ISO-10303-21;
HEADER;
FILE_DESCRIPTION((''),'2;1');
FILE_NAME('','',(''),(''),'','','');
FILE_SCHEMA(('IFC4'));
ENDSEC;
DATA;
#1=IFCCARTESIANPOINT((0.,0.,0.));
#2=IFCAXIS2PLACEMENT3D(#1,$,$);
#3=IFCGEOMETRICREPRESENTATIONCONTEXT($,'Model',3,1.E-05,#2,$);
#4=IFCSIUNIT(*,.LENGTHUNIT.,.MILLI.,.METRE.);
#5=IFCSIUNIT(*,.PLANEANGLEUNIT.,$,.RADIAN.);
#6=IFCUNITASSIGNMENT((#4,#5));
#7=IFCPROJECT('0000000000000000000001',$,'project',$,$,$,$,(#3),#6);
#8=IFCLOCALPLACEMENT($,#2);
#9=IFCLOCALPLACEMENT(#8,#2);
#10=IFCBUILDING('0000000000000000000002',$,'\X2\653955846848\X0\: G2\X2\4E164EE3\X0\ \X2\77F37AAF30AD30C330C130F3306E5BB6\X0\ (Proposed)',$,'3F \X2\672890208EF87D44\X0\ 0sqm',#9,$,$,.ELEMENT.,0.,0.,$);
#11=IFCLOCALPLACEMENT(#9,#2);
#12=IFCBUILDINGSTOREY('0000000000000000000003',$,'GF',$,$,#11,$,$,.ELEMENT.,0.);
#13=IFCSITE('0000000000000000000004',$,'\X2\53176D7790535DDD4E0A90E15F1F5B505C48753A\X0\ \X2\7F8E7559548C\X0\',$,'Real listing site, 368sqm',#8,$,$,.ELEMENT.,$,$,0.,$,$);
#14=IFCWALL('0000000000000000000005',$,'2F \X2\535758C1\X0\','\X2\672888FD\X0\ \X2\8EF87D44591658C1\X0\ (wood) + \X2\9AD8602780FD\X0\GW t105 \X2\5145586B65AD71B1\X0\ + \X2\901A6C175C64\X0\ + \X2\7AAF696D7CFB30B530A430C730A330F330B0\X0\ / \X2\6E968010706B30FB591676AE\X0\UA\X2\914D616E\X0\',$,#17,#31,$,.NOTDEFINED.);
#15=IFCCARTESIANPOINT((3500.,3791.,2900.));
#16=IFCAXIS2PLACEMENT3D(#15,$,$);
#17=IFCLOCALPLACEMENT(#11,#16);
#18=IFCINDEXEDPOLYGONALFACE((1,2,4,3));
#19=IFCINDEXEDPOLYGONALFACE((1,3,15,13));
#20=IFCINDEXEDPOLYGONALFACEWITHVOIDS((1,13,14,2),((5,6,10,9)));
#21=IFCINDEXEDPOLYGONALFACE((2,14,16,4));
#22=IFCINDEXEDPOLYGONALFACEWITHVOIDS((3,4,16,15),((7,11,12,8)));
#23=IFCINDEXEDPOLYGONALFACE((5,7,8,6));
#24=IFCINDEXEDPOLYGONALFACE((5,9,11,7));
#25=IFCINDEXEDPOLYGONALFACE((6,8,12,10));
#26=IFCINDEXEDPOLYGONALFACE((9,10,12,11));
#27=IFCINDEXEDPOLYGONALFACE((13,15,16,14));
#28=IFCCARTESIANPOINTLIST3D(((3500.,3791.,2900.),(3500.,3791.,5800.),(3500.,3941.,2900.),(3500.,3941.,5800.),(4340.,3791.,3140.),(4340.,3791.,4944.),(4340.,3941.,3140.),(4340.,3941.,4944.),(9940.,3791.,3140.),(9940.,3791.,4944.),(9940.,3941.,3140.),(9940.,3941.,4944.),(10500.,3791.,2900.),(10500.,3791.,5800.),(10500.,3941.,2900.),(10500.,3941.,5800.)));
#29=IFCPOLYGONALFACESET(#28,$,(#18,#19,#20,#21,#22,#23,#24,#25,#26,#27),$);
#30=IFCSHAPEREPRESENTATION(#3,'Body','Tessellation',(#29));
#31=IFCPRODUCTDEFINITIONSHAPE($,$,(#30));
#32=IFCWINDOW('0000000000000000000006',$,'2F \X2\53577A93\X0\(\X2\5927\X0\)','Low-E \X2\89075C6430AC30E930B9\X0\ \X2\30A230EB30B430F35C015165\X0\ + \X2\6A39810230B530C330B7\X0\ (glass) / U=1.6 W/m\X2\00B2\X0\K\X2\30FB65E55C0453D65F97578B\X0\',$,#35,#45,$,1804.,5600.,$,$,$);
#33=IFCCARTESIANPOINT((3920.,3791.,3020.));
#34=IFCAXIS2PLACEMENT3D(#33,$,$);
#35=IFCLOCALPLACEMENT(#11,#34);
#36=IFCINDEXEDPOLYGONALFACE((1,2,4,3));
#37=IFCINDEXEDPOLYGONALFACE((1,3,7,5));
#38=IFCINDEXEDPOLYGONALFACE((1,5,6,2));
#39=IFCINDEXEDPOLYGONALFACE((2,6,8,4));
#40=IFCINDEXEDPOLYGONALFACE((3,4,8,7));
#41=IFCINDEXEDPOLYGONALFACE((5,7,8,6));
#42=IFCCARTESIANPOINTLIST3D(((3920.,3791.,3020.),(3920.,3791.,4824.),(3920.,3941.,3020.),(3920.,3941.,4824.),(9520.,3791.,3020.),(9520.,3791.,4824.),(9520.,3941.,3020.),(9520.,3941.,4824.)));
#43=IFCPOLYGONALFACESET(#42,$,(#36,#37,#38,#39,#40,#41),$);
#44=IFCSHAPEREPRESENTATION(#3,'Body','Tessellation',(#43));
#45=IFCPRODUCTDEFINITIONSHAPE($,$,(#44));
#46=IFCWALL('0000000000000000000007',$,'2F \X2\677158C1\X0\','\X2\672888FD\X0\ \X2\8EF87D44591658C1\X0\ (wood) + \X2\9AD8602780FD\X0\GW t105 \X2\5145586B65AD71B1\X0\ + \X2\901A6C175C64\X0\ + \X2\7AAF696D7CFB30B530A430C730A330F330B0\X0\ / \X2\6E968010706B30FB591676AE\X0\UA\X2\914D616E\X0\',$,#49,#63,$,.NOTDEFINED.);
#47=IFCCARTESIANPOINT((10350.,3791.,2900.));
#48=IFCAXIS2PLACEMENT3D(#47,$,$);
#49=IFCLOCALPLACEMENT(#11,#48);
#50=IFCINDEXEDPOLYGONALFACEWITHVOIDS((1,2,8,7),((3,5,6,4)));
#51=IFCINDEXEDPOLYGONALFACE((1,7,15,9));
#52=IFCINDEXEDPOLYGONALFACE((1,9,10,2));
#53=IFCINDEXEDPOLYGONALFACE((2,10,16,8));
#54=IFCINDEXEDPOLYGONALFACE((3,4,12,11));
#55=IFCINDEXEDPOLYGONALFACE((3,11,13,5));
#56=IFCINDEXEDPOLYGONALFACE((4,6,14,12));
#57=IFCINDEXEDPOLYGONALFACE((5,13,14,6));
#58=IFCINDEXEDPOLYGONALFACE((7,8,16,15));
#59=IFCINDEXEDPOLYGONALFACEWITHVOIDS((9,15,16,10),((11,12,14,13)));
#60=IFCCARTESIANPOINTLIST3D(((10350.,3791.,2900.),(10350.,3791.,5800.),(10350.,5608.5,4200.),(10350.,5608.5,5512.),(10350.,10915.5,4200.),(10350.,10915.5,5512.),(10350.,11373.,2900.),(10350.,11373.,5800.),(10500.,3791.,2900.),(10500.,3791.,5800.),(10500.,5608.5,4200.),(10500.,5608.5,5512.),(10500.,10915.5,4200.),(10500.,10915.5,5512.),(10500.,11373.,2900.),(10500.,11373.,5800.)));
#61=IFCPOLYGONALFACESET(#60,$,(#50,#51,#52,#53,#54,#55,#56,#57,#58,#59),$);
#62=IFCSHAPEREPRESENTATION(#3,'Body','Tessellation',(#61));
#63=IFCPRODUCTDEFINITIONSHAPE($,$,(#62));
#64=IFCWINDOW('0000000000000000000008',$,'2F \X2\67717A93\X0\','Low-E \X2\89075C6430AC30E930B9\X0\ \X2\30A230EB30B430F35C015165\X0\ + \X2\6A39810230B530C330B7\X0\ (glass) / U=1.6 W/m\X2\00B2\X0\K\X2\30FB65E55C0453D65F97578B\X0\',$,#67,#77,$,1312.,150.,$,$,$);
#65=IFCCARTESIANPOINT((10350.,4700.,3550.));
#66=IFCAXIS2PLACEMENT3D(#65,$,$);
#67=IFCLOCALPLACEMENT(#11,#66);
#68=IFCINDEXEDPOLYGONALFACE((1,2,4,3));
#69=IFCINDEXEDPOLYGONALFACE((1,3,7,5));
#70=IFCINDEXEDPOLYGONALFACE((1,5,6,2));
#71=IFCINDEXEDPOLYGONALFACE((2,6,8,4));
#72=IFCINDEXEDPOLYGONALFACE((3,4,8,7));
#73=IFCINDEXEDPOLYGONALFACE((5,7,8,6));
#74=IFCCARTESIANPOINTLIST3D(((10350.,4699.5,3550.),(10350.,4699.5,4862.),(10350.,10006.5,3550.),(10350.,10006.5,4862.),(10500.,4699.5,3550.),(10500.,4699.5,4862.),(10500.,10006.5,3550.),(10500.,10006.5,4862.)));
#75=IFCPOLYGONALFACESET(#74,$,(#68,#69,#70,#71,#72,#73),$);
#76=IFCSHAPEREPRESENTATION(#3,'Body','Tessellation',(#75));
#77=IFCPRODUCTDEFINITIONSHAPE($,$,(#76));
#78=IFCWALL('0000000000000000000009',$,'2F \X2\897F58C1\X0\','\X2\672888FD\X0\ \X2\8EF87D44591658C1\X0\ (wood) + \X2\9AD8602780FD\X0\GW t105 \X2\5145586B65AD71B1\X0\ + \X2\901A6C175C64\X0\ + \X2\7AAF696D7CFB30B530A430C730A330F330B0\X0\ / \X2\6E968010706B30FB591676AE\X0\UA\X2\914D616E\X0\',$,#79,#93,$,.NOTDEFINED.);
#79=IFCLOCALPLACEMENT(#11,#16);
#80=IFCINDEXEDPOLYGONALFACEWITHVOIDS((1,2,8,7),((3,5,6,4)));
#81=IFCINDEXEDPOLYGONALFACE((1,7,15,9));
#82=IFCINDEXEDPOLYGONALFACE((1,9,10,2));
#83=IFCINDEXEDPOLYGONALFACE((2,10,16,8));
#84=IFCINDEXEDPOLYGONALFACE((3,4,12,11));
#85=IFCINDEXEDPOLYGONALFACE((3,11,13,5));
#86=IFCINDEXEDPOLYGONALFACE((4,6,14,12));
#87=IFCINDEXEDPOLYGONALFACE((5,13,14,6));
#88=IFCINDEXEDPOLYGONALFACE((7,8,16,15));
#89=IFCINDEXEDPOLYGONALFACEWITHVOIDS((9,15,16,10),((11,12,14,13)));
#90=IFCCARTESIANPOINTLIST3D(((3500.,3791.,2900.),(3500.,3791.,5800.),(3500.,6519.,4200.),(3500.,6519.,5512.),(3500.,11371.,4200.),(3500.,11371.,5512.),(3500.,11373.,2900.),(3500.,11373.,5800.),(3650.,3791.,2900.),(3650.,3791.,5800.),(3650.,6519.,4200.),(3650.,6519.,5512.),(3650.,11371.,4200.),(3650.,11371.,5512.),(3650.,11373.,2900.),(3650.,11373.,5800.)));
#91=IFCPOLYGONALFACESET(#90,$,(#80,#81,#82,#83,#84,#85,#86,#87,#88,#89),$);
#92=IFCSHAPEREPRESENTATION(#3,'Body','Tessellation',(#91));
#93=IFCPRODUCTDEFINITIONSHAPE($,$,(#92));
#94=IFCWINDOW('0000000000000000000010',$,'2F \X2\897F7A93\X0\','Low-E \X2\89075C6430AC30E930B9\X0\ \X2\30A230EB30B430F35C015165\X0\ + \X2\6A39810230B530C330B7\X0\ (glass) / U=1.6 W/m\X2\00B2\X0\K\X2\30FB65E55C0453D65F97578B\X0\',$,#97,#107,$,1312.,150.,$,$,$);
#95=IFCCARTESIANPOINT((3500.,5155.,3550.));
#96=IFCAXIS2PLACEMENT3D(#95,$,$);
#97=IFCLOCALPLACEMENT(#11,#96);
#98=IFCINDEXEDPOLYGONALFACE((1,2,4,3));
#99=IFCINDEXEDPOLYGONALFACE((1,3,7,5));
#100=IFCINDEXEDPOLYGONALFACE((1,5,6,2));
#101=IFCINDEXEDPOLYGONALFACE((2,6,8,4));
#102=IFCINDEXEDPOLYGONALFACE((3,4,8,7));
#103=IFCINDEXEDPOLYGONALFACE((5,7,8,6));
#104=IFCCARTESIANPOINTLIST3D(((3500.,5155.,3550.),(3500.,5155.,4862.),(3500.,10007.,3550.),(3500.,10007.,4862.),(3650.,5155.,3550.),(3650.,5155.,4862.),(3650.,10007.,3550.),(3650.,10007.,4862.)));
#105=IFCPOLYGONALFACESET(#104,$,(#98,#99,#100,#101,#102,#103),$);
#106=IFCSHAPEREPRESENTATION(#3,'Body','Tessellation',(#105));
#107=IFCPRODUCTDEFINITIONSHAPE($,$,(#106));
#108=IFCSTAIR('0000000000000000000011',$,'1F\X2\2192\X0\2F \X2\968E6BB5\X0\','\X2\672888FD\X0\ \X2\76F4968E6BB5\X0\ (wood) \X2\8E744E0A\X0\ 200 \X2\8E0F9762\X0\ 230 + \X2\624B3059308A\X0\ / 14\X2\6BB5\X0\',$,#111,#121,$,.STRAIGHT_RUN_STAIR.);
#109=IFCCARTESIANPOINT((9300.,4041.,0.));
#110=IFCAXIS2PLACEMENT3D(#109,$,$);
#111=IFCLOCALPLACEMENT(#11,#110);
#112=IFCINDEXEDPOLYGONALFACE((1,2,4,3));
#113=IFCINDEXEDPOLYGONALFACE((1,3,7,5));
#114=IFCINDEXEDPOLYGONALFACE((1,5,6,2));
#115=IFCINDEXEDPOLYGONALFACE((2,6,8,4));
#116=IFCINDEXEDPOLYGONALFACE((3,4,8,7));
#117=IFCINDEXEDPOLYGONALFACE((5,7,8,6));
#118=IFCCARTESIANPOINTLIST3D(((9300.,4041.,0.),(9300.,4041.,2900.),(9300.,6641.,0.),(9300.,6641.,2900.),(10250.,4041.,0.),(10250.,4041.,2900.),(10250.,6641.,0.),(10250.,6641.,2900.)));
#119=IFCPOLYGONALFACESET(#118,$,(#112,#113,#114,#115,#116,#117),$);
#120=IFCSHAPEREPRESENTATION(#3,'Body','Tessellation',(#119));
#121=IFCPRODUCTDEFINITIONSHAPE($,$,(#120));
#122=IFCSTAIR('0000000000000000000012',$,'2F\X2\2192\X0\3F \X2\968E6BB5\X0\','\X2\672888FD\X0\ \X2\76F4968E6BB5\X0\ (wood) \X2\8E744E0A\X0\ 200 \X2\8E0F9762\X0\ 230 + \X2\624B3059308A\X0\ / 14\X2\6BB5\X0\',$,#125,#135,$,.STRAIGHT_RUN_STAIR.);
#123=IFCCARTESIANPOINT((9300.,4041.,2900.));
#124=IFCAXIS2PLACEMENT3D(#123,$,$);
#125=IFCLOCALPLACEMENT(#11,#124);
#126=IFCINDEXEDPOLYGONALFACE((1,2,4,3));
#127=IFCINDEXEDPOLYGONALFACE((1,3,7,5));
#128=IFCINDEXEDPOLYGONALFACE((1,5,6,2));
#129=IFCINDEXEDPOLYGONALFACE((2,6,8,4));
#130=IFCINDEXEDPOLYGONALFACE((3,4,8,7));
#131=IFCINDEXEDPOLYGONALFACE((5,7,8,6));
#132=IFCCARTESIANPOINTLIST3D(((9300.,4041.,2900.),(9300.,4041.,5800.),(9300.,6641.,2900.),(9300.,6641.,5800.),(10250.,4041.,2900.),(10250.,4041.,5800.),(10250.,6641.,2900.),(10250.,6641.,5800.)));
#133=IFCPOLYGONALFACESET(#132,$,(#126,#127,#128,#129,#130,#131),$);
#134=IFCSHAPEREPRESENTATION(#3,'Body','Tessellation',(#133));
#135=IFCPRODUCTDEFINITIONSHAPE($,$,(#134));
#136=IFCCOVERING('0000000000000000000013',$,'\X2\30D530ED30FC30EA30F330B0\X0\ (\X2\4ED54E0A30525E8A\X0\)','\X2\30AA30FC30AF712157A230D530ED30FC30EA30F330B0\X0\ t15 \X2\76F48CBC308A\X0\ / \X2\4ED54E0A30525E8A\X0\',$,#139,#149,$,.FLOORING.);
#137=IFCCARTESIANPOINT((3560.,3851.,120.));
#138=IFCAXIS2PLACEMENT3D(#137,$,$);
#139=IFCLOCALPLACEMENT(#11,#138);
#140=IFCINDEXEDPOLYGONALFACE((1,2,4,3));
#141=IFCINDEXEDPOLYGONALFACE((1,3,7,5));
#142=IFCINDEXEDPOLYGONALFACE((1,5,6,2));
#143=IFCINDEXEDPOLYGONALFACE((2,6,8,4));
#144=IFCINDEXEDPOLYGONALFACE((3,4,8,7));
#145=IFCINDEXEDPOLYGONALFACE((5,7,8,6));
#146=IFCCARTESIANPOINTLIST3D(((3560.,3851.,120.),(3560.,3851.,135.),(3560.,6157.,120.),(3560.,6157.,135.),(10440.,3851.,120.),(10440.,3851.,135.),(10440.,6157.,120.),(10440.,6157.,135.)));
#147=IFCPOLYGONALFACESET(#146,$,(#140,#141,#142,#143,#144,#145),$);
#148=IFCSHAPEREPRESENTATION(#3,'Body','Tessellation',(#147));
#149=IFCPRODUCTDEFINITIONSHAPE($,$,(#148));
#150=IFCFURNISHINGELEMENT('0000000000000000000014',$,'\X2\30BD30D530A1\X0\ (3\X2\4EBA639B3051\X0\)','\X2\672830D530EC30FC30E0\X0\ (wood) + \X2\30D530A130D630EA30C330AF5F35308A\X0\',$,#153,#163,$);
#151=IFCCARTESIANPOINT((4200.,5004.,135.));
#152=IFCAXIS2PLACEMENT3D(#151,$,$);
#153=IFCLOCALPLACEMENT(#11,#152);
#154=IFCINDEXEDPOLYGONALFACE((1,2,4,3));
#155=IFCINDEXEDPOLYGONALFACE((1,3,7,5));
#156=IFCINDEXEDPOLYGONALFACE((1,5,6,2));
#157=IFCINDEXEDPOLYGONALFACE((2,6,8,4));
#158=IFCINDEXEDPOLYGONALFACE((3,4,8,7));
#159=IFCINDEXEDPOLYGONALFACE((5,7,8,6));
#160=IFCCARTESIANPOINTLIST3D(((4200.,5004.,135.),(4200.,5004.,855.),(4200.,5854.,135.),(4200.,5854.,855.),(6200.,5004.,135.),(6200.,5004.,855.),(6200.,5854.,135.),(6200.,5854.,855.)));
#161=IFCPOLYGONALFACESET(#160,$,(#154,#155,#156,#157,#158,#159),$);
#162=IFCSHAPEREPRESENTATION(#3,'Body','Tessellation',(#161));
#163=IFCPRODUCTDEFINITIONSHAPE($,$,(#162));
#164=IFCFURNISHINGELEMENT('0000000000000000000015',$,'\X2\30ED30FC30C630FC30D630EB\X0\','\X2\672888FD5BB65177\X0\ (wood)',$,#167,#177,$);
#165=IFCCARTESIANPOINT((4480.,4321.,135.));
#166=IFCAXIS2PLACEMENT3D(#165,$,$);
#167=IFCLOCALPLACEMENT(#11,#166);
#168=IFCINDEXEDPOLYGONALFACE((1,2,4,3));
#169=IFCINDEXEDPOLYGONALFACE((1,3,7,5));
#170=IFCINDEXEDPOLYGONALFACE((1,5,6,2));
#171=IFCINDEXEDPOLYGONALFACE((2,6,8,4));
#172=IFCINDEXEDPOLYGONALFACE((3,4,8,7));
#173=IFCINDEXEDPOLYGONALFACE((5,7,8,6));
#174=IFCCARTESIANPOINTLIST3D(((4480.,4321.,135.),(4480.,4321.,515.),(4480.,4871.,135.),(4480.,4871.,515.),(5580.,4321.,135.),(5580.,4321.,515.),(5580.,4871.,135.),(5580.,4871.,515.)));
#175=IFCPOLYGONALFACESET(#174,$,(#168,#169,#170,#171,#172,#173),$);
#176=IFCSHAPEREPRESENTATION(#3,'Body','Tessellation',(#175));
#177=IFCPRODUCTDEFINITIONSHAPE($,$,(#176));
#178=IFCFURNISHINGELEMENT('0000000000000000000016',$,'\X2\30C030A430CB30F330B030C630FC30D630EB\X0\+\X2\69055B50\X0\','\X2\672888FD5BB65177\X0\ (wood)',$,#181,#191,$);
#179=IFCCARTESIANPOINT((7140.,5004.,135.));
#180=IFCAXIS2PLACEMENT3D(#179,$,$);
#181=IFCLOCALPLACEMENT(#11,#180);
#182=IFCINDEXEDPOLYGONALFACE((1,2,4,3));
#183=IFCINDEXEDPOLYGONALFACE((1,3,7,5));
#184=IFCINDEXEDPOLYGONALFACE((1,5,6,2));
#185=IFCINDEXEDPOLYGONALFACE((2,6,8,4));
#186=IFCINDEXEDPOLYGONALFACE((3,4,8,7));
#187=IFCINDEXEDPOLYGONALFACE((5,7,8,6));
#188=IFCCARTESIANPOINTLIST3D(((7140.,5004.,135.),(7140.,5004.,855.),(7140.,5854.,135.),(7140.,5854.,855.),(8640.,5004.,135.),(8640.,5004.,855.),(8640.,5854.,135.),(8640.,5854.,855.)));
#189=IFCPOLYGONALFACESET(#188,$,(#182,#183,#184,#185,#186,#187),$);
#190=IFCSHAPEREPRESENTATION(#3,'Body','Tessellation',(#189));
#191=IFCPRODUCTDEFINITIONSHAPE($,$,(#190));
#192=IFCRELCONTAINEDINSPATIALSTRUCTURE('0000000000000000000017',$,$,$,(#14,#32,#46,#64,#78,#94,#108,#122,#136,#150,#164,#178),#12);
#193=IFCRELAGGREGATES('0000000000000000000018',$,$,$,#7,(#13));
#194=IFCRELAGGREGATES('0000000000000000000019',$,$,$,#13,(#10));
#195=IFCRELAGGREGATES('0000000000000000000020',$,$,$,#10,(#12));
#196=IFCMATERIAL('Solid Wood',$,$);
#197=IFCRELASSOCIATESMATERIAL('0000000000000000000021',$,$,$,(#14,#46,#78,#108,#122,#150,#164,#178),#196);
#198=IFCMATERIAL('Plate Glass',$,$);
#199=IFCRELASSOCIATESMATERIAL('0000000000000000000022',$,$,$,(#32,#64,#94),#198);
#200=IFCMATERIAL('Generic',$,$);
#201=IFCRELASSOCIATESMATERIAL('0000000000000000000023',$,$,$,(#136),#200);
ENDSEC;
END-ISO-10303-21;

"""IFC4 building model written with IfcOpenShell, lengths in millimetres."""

from ifc_helpers import new_model, si_unit, frame, frame_2d, origin, place, context, project, spatial, rectangle, extrude, material, element, fill, save


model = new_model("IFC4")

# Units and contexts
model_context = context("Model", 3, precision=1e-05, world=origin())
ifc_project = project(units=[si_unit("LENGTHUNIT", "METRE", prefix="MILLI"), si_unit("PLANEANGLEUNIT", "RADIAN")], contexts=[model_context])

# Site, building, storey
site_placement = place(None, origin())
site = spatial("IfcSite", under=ifc_project, at=site_placement, Name="北海道川上郡弟子屈町 美留和", ObjectType="Real listing site, 368sqm", CompositionType="ELEMENT", RefElevation=0.0)
building_placement = place(site_placement, origin())
building = spatial("IfcBuilding", under=site, at=building_placement, Name="改善案: G2世代 石窯キッチンの家 (Proposed)", ObjectType="3F 木造軸組 0sqm", CompositionType="ELEMENT", ElevationOfRefHeight=0.0, ElevationOfTerrain=0.0)
storey_placement = place(building_placement, origin())
storey = spatial("IfcBuildingStorey", under=building, at=storey_placement, Name="GF", CompositionType="ELEMENT", Elevation=0.0)

# Shared definitions
ifc_material_1 = material(Name="Solid Wood")

# Shared definitions
ifc_material_2 = material(Name="Plate Glass")

# Walls, openings, windows
wall_1_placement = place(storey_placement, frame((3500.0, 3791.0, 2900.0)))
wall_1 = element("IfcWall", 1, at=wall_1_placement, inside=storey, material=ifc_material_1, Name="2F 南壁", Description="木製 軸組外壁 (wood) + 高性能GW t105 充填断熱 + 通気層 + 窯業系サイディング / 準耐火・外皮UA配慮", PredefinedType="NOTDEFINED", context=model_context, shape_type="SweptSolid", body=[
    extrude(rectangle(XDim=7000.0, YDim=150.0, at=frame_2d((3500.0, 75.0))), frame((3500.0, 3791.0, 2900.0)), (0.0, 0.0, 1.0), 2900.0),
])
opening_1_placement = place(storey_placement, frame((3920.0, 3791.0, 3020.0)))
opening_1 = element("IfcOpeningElement", 2, at=opening_1_placement, cuts=wall_1, PredefinedType="NOTDEFINED", context=model_context, shape_type="SweptSolid", body=[
    extrude(rectangle(XDim=5600.0, YDim=150.0, at=frame_2d((2800.0, 75.0))), frame((3920.0, 3791.0, 3020.0)), (0.0, 0.0, 1.0), 1804.0),
])
window_1_placement = place(storey_placement, frame((3920.0, 3791.0, 3020.0)))
window_1 = element("IfcWindow", 3, at=window_1_placement, inside=storey, material=ifc_material_2, Name="2F 南窓(大)", Description="Low-E 複層ガラス アルゴン封入 + 樹脂サッシ (glass) / U=1.6 W/m²K・日射取得型", OverallHeight=1804.0, OverallWidth=5600.0, context=model_context, shape_type="SweptSolid", body=[
    extrude(rectangle(XDim=5600.0, YDim=150.0, at=frame_2d((2800.0, 75.0))), frame((3920.0, 3791.0, 3020.0)), (0.0, 0.0, 1.0), 1804.0),
])
fill(opening_1, window_1)
wall_2_placement = place(storey_placement, frame((10350.0, 3791.0, 2900.0)))
wall_2 = element("IfcWall", 4, at=wall_2_placement, inside=storey, material=ifc_material_1, Name="2F 東壁", Description="木製 軸組外壁 (wood) + 高性能GW t105 充填断熱 + 通気層 + 窯業系サイディング / 準耐火・外皮UA配慮", PredefinedType="NOTDEFINED", context=model_context, shape_type="SweptSolid", body=[
    extrude(rectangle(XDim=150.0, YDim=7582.0, at=frame_2d((75.0, 3791.0))), frame((10350.0, 3791.0, 2900.0)), (0.0, 0.0, 1.0), 2900.0),
])
opening_2_placement = place(storey_placement, frame((10350.0, 4700.0, 3550.0)))
opening_2 = element("IfcOpeningElement", 5, at=opening_2_placement, cuts=wall_2, PredefinedType="NOTDEFINED", context=model_context, shape_type="SweptSolid", body=[
    extrude(rectangle(XDim=150.0, YDim=5307.0, at=frame_2d((75.0, 2653.0))), frame((10350.0, 4700.0, 3550.0)), (0.0, 0.0, 1.0), 1312.0),
])
window_2_placement = place(storey_placement, frame((10350.0, 4700.0, 3550.0)))
window_2 = element("IfcWindow", 6, at=window_2_placement, inside=storey, material=ifc_material_2, Name="2F 東窓", Description="Low-E 複層ガラス アルゴン封入 + 樹脂サッシ (glass) / U=1.6 W/m²K・日射取得型", OverallHeight=1312.0, OverallWidth=150.0, context=model_context, shape_type="SweptSolid", body=[
    extrude(rectangle(XDim=150.0, YDim=5307.0, at=frame_2d((75.0, 2653.0))), frame((10350.0, 4700.0, 3550.0)), (0.0, 0.0, 1.0), 1312.0),
])
fill(opening_2, window_2)
wall_3_placement = place(storey_placement, frame((3500.0, 3791.0, 2900.0)))
wall_3 = element("IfcWall", 7, at=wall_3_placement, inside=storey, material=ifc_material_1, Name="2F 西壁", Description="木製 軸組外壁 (wood) + 高性能GW t105 充填断熱 + 通気層 + 窯業系サイディング / 準耐火・外皮UA配慮", PredefinedType="NOTDEFINED", context=model_context, shape_type="SweptSolid", body=[
    extrude(rectangle(XDim=150.0, YDim=7582.0, at=frame_2d((75.0, 3791.0))), frame((3500.0, 3791.0, 2900.0)), (0.0, 0.0, 1.0), 2900.0),
])
opening_3_placement = place(storey_placement, frame((3500.0, 5155.0, 3550.0)))
opening_3 = element("IfcOpeningElement", 8, at=opening_3_placement, cuts=wall_3, PredefinedType="NOTDEFINED", context=model_context, shape_type="SweptSolid", body=[
    extrude(rectangle(XDim=150.0, YDim=4852.0, at=frame_2d((75.0, 2426.0))), frame((3500.0, 5155.0, 3550.0)), (0.0, 0.0, 1.0), 1312.0),
])
window_3_placement = place(storey_placement, frame((3500.0, 5155.0, 3550.0)))
window_3 = element("IfcWindow", 9, at=window_3_placement, inside=storey, material=ifc_material_2, Name="2F 西窓", Description="Low-E 複層ガラス アルゴン封入 + 樹脂サッシ (glass) / U=1.6 W/m²K・日射取得型", OverallHeight=1312.0, OverallWidth=150.0, context=model_context, shape_type="SweptSolid", body=[
    extrude(rectangle(XDim=150.0, YDim=4852.0, at=frame_2d((75.0, 2426.0))), frame((3500.0, 5155.0, 3550.0)), (0.0, 0.0, 1.0), 1312.0),
])
fill(opening_3, window_3)

# Stairs
stair_1_placement = place(storey_placement, frame((9300.0, 4041.0, 0.0)))
element("IfcStair", 10, at=stair_1_placement, inside=storey, material=ifc_material_1, Name="1F→2F 階段", Description="木製 直階段 (wood) 蹴上 200 踏面 230 + 手すり / 14段", PredefinedType="STRAIGHT_RUN_STAIR", context=model_context, shape_type="SweptSolid", body=[
    extrude(rectangle(XDim=950.0, YDim=2600.0, at=frame_2d((475.0, 1300.0))), frame((9300.0, 4041.0, 0.0)), (0.0, 0.0, 1.0), 2900.0),
])
stair_2_placement = place(storey_placement, frame((9300.0, 4041.0, 2900.0)))
element("IfcStair", 11, at=stair_2_placement, inside=storey, material=ifc_material_1, Name="2F→3F 階段", Description="木製 直階段 (wood) 蹴上 200 踏面 230 + 手すり / 14段", PredefinedType="STRAIGHT_RUN_STAIR", context=model_context, shape_type="SweptSolid", body=[
    extrude(rectangle(XDim=950.0, YDim=2600.0, at=frame_2d((475.0, 1300.0))), frame((9300.0, 4041.0, 2900.0)), (0.0, 0.0, 1.0), 2900.0),
])

# Covering
ifc_material_3 = material(Name="Generic")
covering_placement = place(storey_placement, frame((3560.0, 3851.0, 120.0)))
element("IfcCovering", 12, at=covering_placement, inside=storey, material=ifc_material_3, Name="フローリング (仕上げ床)", Description="オーク無垢フローリング t15 直貼り / 仕上げ床", PredefinedType="FLOORING", context=model_context, shape_type="SweptSolid", body=[
    extrude(rectangle(XDim=6880.0, YDim=2306.0, at=frame_2d((3440.0, 1153.0))), frame((3560.0, 3851.0, 120.0)), (0.0, 0.0, 1.0), 15.0),
])

# Furnishing elements
furnishing_1_placement = place(storey_placement, frame((4200.0, 5004.0, 135.0)))
element("IfcFurnishingElement", 13, at=furnishing_1_placement, inside=storey, material=ifc_material_1, Name="ソファ (3人掛け)", Description="木フレーム (wood) + ファブリック張り", context=model_context, shape_type="SweptSolid", body=[
    extrude(rectangle(XDim=2000.0, YDim=850.0, at=frame_2d((1000.0, 425.0))), frame((4200.0, 5004.0, 135.0)), (0.0, 0.0, 1.0), 720.0),
])
furnishing_2_placement = place(storey_placement, frame((4480.0, 4321.0, 135.0)))
element("IfcFurnishingElement", 14, at=furnishing_2_placement, inside=storey, material=ifc_material_1, Name="ローテーブル", Description="木製家具 (wood)", context=model_context, shape_type="SweptSolid", body=[
    extrude(rectangle(XDim=1100.0, YDim=550.0, at=frame_2d((550.0, 275.0))), frame((4480.0, 4321.0, 135.0)), (0.0, 0.0, 1.0), 380.0),
])
furnishing_3_placement = place(storey_placement, frame((7140.0, 5004.0, 135.0)))
element("IfcFurnishingElement", 15, at=furnishing_3_placement, inside=storey, material=ifc_material_1, Name="ダイニングテーブル+椅子", Description="木製家具 (wood)", context=model_context, shape_type="SweptSolid", body=[
    extrude(rectangle(XDim=1500.0, YDim=850.0, at=frame_2d((750.0, 425.0))), frame((7140.0, 5004.0, 135.0)), (0.0, 0.0, 1.0), 720.0),
])

save(model, "model.ifc")
